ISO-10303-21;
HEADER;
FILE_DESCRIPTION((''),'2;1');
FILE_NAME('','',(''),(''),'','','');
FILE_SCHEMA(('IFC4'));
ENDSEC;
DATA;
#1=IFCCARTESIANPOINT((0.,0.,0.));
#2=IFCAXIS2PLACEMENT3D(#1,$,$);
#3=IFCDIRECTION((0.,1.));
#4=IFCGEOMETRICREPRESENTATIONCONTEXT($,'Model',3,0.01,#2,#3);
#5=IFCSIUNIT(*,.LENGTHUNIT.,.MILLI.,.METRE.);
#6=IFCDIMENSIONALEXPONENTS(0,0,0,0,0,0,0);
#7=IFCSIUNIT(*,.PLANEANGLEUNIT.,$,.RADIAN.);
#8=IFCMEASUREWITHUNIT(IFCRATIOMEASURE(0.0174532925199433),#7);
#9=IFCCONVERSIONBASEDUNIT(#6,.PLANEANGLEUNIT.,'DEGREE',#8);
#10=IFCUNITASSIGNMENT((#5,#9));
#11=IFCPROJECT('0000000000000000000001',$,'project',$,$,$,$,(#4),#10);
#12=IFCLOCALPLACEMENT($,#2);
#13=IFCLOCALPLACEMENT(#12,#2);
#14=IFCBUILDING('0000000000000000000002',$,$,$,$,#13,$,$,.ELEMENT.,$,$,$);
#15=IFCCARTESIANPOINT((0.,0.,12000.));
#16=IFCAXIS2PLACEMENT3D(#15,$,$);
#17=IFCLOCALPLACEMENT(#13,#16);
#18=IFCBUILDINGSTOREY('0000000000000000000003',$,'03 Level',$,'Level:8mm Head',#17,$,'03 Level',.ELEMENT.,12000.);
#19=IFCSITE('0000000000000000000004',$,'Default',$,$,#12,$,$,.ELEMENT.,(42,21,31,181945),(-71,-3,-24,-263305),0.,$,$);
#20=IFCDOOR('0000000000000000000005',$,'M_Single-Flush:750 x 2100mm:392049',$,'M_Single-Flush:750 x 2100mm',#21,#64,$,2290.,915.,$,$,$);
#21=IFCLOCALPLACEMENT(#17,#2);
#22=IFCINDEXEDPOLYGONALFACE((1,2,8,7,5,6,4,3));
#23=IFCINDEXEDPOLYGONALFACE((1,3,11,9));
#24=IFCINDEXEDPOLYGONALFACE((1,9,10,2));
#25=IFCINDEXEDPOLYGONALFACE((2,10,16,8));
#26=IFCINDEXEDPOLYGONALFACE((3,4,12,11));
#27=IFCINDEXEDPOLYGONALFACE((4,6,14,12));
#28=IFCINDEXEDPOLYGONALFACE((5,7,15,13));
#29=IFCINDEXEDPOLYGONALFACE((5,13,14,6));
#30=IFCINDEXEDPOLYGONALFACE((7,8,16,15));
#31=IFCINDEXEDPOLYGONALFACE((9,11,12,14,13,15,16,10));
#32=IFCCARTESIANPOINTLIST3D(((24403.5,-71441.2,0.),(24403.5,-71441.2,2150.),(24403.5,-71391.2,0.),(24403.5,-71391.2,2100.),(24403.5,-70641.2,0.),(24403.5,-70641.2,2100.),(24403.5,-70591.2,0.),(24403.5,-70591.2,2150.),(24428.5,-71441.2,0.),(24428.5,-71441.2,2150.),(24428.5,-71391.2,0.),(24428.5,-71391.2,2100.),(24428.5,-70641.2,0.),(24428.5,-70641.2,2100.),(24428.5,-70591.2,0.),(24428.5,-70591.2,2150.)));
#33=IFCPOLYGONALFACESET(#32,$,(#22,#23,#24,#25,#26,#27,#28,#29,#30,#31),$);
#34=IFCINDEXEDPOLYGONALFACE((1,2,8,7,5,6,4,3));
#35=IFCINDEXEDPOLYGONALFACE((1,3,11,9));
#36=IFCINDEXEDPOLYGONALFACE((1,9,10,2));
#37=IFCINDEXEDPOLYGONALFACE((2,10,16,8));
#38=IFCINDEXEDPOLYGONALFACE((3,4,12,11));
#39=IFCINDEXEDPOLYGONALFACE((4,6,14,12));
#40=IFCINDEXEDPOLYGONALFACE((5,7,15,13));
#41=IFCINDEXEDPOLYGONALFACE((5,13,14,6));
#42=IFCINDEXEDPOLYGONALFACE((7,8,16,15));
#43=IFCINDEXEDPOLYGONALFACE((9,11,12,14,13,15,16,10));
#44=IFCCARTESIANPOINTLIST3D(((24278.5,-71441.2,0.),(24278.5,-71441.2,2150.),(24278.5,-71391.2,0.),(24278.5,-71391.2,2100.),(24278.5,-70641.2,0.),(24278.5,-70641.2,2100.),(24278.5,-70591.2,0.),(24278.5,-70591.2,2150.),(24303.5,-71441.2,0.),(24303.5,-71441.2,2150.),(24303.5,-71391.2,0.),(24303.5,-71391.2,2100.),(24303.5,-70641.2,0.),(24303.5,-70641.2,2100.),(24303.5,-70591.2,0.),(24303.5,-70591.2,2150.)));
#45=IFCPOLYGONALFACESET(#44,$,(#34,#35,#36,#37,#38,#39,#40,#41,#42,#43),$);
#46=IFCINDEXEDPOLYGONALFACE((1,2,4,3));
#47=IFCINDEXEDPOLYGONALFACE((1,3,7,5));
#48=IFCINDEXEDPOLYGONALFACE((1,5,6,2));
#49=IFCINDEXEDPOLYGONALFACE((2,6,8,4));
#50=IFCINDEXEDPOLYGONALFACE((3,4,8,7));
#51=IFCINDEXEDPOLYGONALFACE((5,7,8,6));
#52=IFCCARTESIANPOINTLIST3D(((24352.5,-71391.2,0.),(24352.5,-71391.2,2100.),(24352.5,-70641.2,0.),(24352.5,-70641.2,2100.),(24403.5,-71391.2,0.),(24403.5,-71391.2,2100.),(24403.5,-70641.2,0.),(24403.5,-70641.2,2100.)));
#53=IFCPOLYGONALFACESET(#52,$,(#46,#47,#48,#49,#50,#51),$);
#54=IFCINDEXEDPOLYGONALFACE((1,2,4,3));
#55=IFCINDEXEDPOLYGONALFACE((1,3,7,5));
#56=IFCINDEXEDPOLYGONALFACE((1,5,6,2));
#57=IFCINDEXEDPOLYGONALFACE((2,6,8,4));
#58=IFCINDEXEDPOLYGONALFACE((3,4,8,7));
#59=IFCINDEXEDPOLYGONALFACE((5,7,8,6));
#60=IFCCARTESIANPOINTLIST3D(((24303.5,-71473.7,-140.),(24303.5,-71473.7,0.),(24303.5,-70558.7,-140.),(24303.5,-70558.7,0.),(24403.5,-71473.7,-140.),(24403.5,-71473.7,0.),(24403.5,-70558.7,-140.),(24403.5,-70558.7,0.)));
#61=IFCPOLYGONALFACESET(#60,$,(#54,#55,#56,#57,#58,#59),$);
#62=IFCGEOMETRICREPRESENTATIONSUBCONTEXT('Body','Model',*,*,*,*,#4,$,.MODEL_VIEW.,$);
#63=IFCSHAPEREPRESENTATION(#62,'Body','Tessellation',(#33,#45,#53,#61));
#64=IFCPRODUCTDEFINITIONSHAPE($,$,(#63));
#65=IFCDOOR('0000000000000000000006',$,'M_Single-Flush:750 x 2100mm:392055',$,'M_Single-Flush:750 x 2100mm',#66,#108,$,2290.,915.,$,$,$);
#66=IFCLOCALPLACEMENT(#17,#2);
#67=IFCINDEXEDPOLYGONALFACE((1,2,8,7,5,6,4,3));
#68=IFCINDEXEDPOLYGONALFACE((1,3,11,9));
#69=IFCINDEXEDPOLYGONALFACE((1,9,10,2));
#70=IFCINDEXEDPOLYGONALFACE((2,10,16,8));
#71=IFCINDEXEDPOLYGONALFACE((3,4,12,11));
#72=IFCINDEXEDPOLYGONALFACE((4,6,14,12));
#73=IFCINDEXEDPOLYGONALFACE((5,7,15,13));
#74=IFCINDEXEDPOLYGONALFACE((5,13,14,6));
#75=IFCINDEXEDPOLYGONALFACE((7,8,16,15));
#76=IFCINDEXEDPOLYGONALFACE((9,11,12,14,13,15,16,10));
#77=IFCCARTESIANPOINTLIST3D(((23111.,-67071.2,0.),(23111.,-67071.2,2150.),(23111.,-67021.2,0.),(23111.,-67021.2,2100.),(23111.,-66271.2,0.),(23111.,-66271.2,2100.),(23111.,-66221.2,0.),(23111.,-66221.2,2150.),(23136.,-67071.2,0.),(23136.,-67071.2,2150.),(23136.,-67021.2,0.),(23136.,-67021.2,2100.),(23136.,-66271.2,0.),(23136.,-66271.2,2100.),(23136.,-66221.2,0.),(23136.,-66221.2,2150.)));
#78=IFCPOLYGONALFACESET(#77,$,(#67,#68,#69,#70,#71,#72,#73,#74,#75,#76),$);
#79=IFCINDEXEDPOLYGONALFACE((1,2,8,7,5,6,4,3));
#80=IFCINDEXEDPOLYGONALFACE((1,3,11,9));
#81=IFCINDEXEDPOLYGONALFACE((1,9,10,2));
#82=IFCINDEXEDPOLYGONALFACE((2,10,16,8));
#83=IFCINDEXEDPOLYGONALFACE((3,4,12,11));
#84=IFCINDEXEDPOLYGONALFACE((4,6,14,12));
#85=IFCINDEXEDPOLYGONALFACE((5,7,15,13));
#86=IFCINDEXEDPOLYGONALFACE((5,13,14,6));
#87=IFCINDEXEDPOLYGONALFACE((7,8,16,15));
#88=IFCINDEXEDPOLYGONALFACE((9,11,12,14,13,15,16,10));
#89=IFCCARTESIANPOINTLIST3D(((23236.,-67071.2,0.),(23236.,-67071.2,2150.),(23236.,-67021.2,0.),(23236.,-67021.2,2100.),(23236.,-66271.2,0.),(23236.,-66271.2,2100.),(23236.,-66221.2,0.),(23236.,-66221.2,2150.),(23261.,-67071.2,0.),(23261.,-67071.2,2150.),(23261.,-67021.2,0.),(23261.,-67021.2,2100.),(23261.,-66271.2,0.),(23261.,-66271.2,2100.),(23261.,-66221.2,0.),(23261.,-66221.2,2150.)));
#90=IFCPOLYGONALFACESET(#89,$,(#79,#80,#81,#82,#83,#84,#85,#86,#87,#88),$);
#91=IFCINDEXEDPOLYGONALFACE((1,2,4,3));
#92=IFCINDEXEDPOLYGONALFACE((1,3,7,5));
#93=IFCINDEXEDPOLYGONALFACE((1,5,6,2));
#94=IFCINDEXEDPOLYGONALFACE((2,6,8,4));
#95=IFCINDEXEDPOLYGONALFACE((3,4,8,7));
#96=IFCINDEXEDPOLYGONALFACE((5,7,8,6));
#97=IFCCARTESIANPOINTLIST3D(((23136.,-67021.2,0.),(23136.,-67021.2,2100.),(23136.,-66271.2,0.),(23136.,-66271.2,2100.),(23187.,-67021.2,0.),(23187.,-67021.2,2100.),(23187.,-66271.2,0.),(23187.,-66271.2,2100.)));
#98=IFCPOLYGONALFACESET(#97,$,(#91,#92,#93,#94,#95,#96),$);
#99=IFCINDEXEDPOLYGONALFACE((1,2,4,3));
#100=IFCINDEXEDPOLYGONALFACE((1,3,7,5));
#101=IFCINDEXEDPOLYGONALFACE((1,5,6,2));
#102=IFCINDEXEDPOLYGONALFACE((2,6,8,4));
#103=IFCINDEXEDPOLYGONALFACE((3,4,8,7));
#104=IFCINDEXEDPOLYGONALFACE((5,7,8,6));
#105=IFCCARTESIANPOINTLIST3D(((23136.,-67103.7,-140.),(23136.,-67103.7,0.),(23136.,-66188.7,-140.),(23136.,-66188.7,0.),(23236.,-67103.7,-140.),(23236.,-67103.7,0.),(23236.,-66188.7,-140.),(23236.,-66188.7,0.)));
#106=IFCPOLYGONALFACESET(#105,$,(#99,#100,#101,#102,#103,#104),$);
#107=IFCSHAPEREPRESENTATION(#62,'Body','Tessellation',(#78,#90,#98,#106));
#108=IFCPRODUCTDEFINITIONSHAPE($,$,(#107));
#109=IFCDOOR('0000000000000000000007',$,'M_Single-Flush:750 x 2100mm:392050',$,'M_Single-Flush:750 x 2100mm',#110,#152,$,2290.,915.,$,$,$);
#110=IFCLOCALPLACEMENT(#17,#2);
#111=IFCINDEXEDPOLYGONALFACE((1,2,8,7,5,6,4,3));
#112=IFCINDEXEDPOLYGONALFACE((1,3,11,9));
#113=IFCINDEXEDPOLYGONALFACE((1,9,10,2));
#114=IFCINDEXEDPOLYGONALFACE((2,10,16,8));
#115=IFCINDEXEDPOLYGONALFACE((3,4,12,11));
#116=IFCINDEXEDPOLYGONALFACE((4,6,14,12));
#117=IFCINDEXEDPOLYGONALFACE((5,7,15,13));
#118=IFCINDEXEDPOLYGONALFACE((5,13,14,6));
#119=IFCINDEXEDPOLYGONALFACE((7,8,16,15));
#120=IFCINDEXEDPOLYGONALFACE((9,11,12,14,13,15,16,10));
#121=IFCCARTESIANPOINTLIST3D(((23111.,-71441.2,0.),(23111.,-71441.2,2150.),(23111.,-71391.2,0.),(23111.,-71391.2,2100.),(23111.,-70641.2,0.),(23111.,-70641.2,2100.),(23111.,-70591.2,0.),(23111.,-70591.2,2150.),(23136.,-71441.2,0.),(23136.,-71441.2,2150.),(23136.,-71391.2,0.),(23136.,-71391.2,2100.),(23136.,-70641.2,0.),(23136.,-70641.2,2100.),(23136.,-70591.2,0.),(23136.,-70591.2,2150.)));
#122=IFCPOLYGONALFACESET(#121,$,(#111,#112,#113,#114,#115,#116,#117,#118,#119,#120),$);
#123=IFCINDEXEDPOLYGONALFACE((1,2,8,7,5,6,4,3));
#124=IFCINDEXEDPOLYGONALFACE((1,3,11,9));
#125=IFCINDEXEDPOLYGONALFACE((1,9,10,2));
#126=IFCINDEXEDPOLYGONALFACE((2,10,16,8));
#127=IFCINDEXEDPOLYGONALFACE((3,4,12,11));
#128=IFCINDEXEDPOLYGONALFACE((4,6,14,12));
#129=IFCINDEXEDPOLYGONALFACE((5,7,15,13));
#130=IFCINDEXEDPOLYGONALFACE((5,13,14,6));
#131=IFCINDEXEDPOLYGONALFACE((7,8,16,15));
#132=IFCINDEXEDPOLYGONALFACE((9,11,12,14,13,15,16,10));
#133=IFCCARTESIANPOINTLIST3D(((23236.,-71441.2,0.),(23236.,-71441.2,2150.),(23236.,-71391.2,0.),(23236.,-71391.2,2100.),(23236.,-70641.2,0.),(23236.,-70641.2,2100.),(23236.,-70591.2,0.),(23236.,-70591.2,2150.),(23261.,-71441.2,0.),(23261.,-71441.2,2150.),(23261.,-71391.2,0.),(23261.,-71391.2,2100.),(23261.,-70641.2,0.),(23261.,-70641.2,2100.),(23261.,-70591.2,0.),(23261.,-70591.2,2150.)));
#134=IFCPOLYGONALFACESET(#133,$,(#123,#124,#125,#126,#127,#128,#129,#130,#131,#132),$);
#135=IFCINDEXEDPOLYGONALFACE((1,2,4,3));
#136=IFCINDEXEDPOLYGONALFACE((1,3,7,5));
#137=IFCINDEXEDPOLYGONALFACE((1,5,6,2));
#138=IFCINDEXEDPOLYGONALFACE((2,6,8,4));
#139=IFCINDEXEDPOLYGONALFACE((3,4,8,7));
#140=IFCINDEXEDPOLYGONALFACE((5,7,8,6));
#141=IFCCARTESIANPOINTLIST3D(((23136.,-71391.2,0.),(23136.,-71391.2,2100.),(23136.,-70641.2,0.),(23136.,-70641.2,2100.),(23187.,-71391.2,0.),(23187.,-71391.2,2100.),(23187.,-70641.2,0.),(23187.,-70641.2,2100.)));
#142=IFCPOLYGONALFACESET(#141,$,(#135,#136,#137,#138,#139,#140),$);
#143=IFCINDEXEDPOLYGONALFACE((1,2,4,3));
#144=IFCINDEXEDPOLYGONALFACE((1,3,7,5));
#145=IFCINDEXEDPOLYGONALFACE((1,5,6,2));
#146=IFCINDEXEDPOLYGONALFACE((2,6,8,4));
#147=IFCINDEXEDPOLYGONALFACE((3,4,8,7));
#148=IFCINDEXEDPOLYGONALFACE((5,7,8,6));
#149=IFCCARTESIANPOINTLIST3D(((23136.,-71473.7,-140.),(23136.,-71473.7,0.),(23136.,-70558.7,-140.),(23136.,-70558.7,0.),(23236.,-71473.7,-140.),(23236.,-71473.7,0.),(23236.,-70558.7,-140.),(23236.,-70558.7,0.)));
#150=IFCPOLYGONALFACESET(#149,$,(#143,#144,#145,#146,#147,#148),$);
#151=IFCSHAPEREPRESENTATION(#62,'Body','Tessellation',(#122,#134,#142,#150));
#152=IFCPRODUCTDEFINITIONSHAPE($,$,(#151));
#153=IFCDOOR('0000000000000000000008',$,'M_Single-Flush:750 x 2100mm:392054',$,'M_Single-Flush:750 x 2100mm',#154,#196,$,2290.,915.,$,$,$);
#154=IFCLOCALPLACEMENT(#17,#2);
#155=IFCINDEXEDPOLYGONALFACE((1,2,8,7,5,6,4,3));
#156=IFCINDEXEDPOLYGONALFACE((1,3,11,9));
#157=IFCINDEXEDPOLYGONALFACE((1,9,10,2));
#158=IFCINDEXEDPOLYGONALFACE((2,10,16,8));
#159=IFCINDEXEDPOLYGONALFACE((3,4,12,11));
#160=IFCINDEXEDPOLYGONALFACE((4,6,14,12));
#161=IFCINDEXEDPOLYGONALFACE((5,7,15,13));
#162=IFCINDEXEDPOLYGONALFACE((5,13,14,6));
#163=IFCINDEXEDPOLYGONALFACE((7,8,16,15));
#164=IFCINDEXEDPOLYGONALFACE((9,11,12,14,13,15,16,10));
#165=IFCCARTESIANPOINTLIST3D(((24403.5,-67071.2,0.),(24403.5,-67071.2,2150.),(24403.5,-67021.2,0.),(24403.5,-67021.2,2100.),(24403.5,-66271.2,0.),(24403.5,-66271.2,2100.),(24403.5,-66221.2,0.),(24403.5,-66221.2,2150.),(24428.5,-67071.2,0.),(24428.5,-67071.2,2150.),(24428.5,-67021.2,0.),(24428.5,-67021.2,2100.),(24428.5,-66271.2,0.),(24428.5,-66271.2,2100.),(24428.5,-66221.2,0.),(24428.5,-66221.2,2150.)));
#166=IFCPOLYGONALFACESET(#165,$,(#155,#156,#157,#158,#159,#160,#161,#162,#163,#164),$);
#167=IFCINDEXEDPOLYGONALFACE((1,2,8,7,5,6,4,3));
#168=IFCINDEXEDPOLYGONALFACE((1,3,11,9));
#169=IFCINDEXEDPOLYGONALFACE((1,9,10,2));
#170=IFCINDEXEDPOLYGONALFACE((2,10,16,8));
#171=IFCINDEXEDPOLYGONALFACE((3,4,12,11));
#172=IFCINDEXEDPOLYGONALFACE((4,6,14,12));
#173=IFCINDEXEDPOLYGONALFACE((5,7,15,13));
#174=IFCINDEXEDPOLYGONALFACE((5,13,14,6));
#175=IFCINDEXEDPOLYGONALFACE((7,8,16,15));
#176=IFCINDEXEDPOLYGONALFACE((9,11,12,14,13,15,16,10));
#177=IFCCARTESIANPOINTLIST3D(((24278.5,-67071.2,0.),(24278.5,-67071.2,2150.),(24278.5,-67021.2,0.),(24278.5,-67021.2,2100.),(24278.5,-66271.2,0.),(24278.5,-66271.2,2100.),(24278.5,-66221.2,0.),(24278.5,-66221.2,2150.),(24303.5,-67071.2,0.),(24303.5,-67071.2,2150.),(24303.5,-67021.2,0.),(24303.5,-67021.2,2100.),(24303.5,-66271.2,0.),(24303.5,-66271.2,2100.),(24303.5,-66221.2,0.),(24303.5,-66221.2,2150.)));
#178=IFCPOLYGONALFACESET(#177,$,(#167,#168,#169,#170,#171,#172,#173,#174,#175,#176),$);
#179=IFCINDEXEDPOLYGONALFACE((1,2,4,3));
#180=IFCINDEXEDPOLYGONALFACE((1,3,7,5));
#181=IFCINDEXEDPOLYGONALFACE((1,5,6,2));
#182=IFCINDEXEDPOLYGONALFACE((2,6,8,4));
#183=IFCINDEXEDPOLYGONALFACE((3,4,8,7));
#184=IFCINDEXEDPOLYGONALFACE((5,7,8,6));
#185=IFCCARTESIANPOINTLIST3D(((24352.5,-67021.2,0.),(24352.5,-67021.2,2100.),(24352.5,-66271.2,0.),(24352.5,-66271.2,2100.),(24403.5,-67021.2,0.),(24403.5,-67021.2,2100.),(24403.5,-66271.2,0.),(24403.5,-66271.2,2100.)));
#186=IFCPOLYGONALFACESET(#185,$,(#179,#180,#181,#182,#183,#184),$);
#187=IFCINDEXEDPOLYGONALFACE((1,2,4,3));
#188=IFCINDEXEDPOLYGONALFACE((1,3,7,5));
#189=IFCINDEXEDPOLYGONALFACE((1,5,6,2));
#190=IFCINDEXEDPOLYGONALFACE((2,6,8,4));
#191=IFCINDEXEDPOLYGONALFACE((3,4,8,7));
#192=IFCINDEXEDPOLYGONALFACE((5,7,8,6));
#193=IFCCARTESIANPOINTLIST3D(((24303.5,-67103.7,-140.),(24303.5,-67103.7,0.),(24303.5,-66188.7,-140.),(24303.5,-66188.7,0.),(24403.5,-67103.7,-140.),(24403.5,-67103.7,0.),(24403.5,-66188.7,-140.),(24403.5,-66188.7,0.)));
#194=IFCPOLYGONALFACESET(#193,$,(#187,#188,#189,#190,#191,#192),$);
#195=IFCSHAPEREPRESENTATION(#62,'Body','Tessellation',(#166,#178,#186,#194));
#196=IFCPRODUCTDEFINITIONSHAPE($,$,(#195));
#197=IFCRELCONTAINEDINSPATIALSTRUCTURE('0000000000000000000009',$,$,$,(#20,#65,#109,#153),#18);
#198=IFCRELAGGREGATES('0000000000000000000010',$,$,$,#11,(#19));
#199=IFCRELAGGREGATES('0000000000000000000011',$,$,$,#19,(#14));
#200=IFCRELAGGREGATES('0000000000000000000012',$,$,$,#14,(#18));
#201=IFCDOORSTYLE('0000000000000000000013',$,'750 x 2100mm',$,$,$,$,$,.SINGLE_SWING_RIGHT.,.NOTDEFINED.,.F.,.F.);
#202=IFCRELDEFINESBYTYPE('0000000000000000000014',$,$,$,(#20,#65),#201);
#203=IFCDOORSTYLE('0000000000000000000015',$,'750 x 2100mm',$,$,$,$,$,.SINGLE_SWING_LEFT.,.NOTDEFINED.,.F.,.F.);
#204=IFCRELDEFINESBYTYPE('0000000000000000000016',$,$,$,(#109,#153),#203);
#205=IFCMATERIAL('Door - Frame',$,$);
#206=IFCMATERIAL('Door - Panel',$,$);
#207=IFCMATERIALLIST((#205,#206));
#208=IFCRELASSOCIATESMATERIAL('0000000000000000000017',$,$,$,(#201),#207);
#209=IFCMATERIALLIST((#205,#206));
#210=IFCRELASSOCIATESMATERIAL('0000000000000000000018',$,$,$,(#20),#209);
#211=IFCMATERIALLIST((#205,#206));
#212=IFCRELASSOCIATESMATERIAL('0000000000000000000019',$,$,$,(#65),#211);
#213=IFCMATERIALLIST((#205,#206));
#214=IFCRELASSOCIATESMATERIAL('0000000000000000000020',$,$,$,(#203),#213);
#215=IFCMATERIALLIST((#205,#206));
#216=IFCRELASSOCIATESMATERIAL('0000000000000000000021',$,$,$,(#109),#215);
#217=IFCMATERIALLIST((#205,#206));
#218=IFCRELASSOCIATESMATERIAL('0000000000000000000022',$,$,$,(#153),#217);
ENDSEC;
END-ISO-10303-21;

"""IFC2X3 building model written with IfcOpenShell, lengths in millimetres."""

from ifc_helpers import new_model, entity, si_unit, converted_unit, direction, frame, frame_2d, origin, origin_2d_with_axis, place, context, subcontext, project, spatial, polyline, rectangle, outline, extrude, source, transform, mapped, material, material_list, type_object, type_shapes, element, save


model = new_model("IFC2X3")

# Units and contexts
model_context = context("Model", 3, precision=0.01, world=origin(), true_north=direction((0.0, 1.0)))
body_context = subcontext(model_context, "Body", "Model", "MODEL_VIEW")
ifc_project = project(units=[si_unit("LENGTHUNIT", "METRE", prefix="MILLI"), converted_unit("PLANEANGLEUNIT", "DEGREE", entity("IfcRatioMeasure", 0.0174532925199433), si_unit("PLANEANGLEUNIT", "RADIAN"), dimensions=[0, 0, 0, 0, 0, 0, 0])], contexts=[model_context])

# Site, building, storey
site_placement = place(None, origin())
site = spatial("IfcSite", under=ifc_project, at=site_placement, Name="Default", CompositionType="ELEMENT", RefLatitude=(42, 21, 31, 181945), RefLongitude=(-71, -3, -24, -263305), RefElevation=0.0)
building_placement = place(site_placement, origin())
building = spatial("IfcBuilding", under=site, at=building_placement, CompositionType="ELEMENT")
storey_placement = place(building_placement, frame((0.0, 0.0, 12000.0)))
storey = spatial("IfcBuildingStorey", under=building, at=storey_placement, Name="03 Level", ObjectType="Level:8mm Head", LongName="03 Level", CompositionType="ELEMENT", Elevation=12000.0)

# Shared definitions
ifc_material_1 = material(Name="Door - Frame")
ifc_material_2 = material(Name="Door - Panel")

# Doors
ifc_material_list_1 = material_list([ifc_material_1, ifc_material_2])
ifc_material_list_2 = material_list([ifc_material_1, ifc_material_2])
door_style_1 = type_object("IfcDoorStyle", Name="750 x 2100mm", ConstructionType="NOTDEFINED", OperationType="SINGLE_SWING_RIGHT", ParameterTakesPrecedence=False, Sizeable=False, material=ifc_material_list_2)
shared_shape_1 = source(origin(), body_context, "Body", "SweptSolid", [
    extrude(outline(polyline([(-425.0, -1087.5), (425.0, -1087.5), (425.0, 1062.5), (375.0, 1062.5), (375.0, -1037.5), (-375.0, -1037.5), (-375.0, 1062.5), (-425.0, 1062.5), (-425.0, -1087.5)])), frame((375.0, 100.0, 1202.5), z_axis=(0.0, 1.0, 0.0), x_axis=(1.0, 0.0, 0.0)), (0.0, 0.0, 1.0), 25.0),
    extrude(outline(polyline([(-1087.5, -425.0), (1062.5, -425.0), (1062.5, -375.0), (-1037.5, -375.0), (-1037.5, 375.0), (1062.5, 375.0), (1062.5, 425.0), (-1087.5, 425.0), (-1087.5, -425.0)])), frame((375.0, -25.0, 1202.5), z_axis=(0.0, 1.0, 0.0), x_axis=(0.0, 0.0, -1.0)), (0.0, 0.0, 1.0), 25.0),
    extrude(rectangle(XDim=51.0, YDim=750.0, at=origin_2d_with_axis()), frame((375.0, 74.5, 140.0), z_axis=(0.0, 0.0, 1.0), x_axis=(0.0, 1.0, 0.0)), (0.0, 0.0, 1.0), 2100.0),
    extrude(rectangle(XDim=915.0, YDim=100.0, at=frame_2d((0.0, 0.0), x_axis=(1.0, 0.0))), frame((375.0, 50.0, 0.0), z_axis=(0.0, 0.0, 1.0), x_axis=(-1.0, 0.0, 0.0)), (0.0, 0.0, 1.0), 140.0),
])
type_shapes(door_style_1, [shared_shape_1])
door_1_placement = place(storey_placement, frame((24303.5, -70641.2, -140.0), z_axis=(0.0, 0.0, 1.0), x_axis=(0.0, -1.0, 0.0)))
element("IfcDoor", 1, at=door_1_placement, inside=storey, type_object=door_style_1, material=ifc_material_list_1, Name="M_Single-Flush:750 x 2100mm:392049", ObjectType="M_Single-Flush:750 x 2100mm", OverallHeight=2290.0, OverallWidth=915.0, context=body_context, shape_type="MappedRepresentation", body=[
    mapped(shared_shape_1, transform((0.0, 0.0, 0.0), scale=1.0)),
])
ifc_material_list_3 = material_list([ifc_material_1, ifc_material_2])
door_2_placement = place(storey_placement, frame((23236.0, -67021.2, -140.0), z_axis=(0.0, 0.0, 1.0), x_axis=(0.0, 1.0, 0.0)))
element("IfcDoor", 2, at=door_2_placement, inside=storey, type_object=door_style_1, material=ifc_material_list_3, Name="M_Single-Flush:750 x 2100mm:392055", ObjectType="M_Single-Flush:750 x 2100mm", OverallHeight=2290.0, OverallWidth=915.0, context=body_context, shape_type="MappedRepresentation", body=[
    mapped(shared_shape_1, transform((0.0, 0.0, 0.0), scale=1.0)),
])
ifc_material_list_4 = material_list([ifc_material_1, ifc_material_2])
ifc_material_list_5 = material_list([ifc_material_1, ifc_material_2])
door_style_2 = type_object("IfcDoorStyle", Name="750 x 2100mm", ConstructionType="NOTDEFINED", OperationType="SINGLE_SWING_LEFT", ParameterTakesPrecedence=False, Sizeable=False, material=ifc_material_list_5)
shared_shape_2 = source(origin(), body_context, "Body", "SweptSolid", [
    extrude(outline(polyline([(-425.0, -1087.5), (425.0, -1087.5), (425.0, 1062.5), (375.0, 1062.5), (375.0, -1037.5), (-375.0, -1037.5), (-375.0, 1062.5), (-425.0, 1062.5), (-425.0, -1087.5)])), frame((375.0, 125.0, 1202.5), z_axis=(0.0, -1.0, 0.0), x_axis=(-1.0, 0.0, 0.0)), (0.0, 0.0, 1.0), 25.0),
    extrude(outline(polyline([(-1087.5, -425.0), (1062.5, -425.0), (1062.5, -375.0), (-1037.5, -375.0), (-1037.5, 375.0), (1062.5, 375.0), (1062.5, 425.0), (-1087.5, 425.0), (-1087.5, -425.0)])), frame((375.0, 0.0, 1202.5), z_axis=(0.0, -1.0, 0.0), x_axis=(0.0, 0.0, -1.0)), (0.0, 0.0, 1.0), 25.0),
    extrude(rectangle(XDim=750.0, YDim=51.0, at=origin_2d_with_axis()), frame((375.0, 74.5, 140.0)), (0.0, 0.0, 1.0), 2100.0),
    extrude(rectangle(XDim=100.0, YDim=915.0, at=origin_2d_with_axis()), frame((375.0, 50.0, 0.0), z_axis=(0.0, 0.0, 1.0), x_axis=(0.0, -1.0, 0.0)), (0.0, 0.0, 1.0), 140.0),
])
type_shapes(door_style_2, [shared_shape_2])
door_3_placement = place(storey_placement, frame((23236.0, -71391.2, -140.0), z_axis=(0.0, 0.0, 1.0), x_axis=(0.0, 1.0, 0.0)))
element("IfcDoor", 3, at=door_3_placement, inside=storey, type_object=door_style_2, material=ifc_material_list_4, Name="M_Single-Flush:750 x 2100mm:392050", ObjectType="M_Single-Flush:750 x 2100mm", OverallHeight=2290.0, OverallWidth=915.0, context=body_context, shape_type="MappedRepresentation", body=[
    mapped(shared_shape_2, transform((0.0, 0.0, 0.0), scale=1.0)),
])
ifc_material_list_6 = material_list([ifc_material_1, ifc_material_2])
door_4_placement = place(storey_placement, frame((24303.5, -66271.2, -140.0), z_axis=(0.0, 0.0, 1.0), x_axis=(0.0, -1.0, 0.0)))
element("IfcDoor", 4, at=door_4_placement, inside=storey, type_object=door_style_2, material=ifc_material_list_6, Name="M_Single-Flush:750 x 2100mm:392054", ObjectType="M_Single-Flush:750 x 2100mm", OverallHeight=2290.0, OverallWidth=915.0, context=body_context, shape_type="MappedRepresentation", body=[
    mapped(shared_shape_2, transform((0.0, 0.0, 0.0), scale=1.0)),
])

save(model, "model.ifc")
